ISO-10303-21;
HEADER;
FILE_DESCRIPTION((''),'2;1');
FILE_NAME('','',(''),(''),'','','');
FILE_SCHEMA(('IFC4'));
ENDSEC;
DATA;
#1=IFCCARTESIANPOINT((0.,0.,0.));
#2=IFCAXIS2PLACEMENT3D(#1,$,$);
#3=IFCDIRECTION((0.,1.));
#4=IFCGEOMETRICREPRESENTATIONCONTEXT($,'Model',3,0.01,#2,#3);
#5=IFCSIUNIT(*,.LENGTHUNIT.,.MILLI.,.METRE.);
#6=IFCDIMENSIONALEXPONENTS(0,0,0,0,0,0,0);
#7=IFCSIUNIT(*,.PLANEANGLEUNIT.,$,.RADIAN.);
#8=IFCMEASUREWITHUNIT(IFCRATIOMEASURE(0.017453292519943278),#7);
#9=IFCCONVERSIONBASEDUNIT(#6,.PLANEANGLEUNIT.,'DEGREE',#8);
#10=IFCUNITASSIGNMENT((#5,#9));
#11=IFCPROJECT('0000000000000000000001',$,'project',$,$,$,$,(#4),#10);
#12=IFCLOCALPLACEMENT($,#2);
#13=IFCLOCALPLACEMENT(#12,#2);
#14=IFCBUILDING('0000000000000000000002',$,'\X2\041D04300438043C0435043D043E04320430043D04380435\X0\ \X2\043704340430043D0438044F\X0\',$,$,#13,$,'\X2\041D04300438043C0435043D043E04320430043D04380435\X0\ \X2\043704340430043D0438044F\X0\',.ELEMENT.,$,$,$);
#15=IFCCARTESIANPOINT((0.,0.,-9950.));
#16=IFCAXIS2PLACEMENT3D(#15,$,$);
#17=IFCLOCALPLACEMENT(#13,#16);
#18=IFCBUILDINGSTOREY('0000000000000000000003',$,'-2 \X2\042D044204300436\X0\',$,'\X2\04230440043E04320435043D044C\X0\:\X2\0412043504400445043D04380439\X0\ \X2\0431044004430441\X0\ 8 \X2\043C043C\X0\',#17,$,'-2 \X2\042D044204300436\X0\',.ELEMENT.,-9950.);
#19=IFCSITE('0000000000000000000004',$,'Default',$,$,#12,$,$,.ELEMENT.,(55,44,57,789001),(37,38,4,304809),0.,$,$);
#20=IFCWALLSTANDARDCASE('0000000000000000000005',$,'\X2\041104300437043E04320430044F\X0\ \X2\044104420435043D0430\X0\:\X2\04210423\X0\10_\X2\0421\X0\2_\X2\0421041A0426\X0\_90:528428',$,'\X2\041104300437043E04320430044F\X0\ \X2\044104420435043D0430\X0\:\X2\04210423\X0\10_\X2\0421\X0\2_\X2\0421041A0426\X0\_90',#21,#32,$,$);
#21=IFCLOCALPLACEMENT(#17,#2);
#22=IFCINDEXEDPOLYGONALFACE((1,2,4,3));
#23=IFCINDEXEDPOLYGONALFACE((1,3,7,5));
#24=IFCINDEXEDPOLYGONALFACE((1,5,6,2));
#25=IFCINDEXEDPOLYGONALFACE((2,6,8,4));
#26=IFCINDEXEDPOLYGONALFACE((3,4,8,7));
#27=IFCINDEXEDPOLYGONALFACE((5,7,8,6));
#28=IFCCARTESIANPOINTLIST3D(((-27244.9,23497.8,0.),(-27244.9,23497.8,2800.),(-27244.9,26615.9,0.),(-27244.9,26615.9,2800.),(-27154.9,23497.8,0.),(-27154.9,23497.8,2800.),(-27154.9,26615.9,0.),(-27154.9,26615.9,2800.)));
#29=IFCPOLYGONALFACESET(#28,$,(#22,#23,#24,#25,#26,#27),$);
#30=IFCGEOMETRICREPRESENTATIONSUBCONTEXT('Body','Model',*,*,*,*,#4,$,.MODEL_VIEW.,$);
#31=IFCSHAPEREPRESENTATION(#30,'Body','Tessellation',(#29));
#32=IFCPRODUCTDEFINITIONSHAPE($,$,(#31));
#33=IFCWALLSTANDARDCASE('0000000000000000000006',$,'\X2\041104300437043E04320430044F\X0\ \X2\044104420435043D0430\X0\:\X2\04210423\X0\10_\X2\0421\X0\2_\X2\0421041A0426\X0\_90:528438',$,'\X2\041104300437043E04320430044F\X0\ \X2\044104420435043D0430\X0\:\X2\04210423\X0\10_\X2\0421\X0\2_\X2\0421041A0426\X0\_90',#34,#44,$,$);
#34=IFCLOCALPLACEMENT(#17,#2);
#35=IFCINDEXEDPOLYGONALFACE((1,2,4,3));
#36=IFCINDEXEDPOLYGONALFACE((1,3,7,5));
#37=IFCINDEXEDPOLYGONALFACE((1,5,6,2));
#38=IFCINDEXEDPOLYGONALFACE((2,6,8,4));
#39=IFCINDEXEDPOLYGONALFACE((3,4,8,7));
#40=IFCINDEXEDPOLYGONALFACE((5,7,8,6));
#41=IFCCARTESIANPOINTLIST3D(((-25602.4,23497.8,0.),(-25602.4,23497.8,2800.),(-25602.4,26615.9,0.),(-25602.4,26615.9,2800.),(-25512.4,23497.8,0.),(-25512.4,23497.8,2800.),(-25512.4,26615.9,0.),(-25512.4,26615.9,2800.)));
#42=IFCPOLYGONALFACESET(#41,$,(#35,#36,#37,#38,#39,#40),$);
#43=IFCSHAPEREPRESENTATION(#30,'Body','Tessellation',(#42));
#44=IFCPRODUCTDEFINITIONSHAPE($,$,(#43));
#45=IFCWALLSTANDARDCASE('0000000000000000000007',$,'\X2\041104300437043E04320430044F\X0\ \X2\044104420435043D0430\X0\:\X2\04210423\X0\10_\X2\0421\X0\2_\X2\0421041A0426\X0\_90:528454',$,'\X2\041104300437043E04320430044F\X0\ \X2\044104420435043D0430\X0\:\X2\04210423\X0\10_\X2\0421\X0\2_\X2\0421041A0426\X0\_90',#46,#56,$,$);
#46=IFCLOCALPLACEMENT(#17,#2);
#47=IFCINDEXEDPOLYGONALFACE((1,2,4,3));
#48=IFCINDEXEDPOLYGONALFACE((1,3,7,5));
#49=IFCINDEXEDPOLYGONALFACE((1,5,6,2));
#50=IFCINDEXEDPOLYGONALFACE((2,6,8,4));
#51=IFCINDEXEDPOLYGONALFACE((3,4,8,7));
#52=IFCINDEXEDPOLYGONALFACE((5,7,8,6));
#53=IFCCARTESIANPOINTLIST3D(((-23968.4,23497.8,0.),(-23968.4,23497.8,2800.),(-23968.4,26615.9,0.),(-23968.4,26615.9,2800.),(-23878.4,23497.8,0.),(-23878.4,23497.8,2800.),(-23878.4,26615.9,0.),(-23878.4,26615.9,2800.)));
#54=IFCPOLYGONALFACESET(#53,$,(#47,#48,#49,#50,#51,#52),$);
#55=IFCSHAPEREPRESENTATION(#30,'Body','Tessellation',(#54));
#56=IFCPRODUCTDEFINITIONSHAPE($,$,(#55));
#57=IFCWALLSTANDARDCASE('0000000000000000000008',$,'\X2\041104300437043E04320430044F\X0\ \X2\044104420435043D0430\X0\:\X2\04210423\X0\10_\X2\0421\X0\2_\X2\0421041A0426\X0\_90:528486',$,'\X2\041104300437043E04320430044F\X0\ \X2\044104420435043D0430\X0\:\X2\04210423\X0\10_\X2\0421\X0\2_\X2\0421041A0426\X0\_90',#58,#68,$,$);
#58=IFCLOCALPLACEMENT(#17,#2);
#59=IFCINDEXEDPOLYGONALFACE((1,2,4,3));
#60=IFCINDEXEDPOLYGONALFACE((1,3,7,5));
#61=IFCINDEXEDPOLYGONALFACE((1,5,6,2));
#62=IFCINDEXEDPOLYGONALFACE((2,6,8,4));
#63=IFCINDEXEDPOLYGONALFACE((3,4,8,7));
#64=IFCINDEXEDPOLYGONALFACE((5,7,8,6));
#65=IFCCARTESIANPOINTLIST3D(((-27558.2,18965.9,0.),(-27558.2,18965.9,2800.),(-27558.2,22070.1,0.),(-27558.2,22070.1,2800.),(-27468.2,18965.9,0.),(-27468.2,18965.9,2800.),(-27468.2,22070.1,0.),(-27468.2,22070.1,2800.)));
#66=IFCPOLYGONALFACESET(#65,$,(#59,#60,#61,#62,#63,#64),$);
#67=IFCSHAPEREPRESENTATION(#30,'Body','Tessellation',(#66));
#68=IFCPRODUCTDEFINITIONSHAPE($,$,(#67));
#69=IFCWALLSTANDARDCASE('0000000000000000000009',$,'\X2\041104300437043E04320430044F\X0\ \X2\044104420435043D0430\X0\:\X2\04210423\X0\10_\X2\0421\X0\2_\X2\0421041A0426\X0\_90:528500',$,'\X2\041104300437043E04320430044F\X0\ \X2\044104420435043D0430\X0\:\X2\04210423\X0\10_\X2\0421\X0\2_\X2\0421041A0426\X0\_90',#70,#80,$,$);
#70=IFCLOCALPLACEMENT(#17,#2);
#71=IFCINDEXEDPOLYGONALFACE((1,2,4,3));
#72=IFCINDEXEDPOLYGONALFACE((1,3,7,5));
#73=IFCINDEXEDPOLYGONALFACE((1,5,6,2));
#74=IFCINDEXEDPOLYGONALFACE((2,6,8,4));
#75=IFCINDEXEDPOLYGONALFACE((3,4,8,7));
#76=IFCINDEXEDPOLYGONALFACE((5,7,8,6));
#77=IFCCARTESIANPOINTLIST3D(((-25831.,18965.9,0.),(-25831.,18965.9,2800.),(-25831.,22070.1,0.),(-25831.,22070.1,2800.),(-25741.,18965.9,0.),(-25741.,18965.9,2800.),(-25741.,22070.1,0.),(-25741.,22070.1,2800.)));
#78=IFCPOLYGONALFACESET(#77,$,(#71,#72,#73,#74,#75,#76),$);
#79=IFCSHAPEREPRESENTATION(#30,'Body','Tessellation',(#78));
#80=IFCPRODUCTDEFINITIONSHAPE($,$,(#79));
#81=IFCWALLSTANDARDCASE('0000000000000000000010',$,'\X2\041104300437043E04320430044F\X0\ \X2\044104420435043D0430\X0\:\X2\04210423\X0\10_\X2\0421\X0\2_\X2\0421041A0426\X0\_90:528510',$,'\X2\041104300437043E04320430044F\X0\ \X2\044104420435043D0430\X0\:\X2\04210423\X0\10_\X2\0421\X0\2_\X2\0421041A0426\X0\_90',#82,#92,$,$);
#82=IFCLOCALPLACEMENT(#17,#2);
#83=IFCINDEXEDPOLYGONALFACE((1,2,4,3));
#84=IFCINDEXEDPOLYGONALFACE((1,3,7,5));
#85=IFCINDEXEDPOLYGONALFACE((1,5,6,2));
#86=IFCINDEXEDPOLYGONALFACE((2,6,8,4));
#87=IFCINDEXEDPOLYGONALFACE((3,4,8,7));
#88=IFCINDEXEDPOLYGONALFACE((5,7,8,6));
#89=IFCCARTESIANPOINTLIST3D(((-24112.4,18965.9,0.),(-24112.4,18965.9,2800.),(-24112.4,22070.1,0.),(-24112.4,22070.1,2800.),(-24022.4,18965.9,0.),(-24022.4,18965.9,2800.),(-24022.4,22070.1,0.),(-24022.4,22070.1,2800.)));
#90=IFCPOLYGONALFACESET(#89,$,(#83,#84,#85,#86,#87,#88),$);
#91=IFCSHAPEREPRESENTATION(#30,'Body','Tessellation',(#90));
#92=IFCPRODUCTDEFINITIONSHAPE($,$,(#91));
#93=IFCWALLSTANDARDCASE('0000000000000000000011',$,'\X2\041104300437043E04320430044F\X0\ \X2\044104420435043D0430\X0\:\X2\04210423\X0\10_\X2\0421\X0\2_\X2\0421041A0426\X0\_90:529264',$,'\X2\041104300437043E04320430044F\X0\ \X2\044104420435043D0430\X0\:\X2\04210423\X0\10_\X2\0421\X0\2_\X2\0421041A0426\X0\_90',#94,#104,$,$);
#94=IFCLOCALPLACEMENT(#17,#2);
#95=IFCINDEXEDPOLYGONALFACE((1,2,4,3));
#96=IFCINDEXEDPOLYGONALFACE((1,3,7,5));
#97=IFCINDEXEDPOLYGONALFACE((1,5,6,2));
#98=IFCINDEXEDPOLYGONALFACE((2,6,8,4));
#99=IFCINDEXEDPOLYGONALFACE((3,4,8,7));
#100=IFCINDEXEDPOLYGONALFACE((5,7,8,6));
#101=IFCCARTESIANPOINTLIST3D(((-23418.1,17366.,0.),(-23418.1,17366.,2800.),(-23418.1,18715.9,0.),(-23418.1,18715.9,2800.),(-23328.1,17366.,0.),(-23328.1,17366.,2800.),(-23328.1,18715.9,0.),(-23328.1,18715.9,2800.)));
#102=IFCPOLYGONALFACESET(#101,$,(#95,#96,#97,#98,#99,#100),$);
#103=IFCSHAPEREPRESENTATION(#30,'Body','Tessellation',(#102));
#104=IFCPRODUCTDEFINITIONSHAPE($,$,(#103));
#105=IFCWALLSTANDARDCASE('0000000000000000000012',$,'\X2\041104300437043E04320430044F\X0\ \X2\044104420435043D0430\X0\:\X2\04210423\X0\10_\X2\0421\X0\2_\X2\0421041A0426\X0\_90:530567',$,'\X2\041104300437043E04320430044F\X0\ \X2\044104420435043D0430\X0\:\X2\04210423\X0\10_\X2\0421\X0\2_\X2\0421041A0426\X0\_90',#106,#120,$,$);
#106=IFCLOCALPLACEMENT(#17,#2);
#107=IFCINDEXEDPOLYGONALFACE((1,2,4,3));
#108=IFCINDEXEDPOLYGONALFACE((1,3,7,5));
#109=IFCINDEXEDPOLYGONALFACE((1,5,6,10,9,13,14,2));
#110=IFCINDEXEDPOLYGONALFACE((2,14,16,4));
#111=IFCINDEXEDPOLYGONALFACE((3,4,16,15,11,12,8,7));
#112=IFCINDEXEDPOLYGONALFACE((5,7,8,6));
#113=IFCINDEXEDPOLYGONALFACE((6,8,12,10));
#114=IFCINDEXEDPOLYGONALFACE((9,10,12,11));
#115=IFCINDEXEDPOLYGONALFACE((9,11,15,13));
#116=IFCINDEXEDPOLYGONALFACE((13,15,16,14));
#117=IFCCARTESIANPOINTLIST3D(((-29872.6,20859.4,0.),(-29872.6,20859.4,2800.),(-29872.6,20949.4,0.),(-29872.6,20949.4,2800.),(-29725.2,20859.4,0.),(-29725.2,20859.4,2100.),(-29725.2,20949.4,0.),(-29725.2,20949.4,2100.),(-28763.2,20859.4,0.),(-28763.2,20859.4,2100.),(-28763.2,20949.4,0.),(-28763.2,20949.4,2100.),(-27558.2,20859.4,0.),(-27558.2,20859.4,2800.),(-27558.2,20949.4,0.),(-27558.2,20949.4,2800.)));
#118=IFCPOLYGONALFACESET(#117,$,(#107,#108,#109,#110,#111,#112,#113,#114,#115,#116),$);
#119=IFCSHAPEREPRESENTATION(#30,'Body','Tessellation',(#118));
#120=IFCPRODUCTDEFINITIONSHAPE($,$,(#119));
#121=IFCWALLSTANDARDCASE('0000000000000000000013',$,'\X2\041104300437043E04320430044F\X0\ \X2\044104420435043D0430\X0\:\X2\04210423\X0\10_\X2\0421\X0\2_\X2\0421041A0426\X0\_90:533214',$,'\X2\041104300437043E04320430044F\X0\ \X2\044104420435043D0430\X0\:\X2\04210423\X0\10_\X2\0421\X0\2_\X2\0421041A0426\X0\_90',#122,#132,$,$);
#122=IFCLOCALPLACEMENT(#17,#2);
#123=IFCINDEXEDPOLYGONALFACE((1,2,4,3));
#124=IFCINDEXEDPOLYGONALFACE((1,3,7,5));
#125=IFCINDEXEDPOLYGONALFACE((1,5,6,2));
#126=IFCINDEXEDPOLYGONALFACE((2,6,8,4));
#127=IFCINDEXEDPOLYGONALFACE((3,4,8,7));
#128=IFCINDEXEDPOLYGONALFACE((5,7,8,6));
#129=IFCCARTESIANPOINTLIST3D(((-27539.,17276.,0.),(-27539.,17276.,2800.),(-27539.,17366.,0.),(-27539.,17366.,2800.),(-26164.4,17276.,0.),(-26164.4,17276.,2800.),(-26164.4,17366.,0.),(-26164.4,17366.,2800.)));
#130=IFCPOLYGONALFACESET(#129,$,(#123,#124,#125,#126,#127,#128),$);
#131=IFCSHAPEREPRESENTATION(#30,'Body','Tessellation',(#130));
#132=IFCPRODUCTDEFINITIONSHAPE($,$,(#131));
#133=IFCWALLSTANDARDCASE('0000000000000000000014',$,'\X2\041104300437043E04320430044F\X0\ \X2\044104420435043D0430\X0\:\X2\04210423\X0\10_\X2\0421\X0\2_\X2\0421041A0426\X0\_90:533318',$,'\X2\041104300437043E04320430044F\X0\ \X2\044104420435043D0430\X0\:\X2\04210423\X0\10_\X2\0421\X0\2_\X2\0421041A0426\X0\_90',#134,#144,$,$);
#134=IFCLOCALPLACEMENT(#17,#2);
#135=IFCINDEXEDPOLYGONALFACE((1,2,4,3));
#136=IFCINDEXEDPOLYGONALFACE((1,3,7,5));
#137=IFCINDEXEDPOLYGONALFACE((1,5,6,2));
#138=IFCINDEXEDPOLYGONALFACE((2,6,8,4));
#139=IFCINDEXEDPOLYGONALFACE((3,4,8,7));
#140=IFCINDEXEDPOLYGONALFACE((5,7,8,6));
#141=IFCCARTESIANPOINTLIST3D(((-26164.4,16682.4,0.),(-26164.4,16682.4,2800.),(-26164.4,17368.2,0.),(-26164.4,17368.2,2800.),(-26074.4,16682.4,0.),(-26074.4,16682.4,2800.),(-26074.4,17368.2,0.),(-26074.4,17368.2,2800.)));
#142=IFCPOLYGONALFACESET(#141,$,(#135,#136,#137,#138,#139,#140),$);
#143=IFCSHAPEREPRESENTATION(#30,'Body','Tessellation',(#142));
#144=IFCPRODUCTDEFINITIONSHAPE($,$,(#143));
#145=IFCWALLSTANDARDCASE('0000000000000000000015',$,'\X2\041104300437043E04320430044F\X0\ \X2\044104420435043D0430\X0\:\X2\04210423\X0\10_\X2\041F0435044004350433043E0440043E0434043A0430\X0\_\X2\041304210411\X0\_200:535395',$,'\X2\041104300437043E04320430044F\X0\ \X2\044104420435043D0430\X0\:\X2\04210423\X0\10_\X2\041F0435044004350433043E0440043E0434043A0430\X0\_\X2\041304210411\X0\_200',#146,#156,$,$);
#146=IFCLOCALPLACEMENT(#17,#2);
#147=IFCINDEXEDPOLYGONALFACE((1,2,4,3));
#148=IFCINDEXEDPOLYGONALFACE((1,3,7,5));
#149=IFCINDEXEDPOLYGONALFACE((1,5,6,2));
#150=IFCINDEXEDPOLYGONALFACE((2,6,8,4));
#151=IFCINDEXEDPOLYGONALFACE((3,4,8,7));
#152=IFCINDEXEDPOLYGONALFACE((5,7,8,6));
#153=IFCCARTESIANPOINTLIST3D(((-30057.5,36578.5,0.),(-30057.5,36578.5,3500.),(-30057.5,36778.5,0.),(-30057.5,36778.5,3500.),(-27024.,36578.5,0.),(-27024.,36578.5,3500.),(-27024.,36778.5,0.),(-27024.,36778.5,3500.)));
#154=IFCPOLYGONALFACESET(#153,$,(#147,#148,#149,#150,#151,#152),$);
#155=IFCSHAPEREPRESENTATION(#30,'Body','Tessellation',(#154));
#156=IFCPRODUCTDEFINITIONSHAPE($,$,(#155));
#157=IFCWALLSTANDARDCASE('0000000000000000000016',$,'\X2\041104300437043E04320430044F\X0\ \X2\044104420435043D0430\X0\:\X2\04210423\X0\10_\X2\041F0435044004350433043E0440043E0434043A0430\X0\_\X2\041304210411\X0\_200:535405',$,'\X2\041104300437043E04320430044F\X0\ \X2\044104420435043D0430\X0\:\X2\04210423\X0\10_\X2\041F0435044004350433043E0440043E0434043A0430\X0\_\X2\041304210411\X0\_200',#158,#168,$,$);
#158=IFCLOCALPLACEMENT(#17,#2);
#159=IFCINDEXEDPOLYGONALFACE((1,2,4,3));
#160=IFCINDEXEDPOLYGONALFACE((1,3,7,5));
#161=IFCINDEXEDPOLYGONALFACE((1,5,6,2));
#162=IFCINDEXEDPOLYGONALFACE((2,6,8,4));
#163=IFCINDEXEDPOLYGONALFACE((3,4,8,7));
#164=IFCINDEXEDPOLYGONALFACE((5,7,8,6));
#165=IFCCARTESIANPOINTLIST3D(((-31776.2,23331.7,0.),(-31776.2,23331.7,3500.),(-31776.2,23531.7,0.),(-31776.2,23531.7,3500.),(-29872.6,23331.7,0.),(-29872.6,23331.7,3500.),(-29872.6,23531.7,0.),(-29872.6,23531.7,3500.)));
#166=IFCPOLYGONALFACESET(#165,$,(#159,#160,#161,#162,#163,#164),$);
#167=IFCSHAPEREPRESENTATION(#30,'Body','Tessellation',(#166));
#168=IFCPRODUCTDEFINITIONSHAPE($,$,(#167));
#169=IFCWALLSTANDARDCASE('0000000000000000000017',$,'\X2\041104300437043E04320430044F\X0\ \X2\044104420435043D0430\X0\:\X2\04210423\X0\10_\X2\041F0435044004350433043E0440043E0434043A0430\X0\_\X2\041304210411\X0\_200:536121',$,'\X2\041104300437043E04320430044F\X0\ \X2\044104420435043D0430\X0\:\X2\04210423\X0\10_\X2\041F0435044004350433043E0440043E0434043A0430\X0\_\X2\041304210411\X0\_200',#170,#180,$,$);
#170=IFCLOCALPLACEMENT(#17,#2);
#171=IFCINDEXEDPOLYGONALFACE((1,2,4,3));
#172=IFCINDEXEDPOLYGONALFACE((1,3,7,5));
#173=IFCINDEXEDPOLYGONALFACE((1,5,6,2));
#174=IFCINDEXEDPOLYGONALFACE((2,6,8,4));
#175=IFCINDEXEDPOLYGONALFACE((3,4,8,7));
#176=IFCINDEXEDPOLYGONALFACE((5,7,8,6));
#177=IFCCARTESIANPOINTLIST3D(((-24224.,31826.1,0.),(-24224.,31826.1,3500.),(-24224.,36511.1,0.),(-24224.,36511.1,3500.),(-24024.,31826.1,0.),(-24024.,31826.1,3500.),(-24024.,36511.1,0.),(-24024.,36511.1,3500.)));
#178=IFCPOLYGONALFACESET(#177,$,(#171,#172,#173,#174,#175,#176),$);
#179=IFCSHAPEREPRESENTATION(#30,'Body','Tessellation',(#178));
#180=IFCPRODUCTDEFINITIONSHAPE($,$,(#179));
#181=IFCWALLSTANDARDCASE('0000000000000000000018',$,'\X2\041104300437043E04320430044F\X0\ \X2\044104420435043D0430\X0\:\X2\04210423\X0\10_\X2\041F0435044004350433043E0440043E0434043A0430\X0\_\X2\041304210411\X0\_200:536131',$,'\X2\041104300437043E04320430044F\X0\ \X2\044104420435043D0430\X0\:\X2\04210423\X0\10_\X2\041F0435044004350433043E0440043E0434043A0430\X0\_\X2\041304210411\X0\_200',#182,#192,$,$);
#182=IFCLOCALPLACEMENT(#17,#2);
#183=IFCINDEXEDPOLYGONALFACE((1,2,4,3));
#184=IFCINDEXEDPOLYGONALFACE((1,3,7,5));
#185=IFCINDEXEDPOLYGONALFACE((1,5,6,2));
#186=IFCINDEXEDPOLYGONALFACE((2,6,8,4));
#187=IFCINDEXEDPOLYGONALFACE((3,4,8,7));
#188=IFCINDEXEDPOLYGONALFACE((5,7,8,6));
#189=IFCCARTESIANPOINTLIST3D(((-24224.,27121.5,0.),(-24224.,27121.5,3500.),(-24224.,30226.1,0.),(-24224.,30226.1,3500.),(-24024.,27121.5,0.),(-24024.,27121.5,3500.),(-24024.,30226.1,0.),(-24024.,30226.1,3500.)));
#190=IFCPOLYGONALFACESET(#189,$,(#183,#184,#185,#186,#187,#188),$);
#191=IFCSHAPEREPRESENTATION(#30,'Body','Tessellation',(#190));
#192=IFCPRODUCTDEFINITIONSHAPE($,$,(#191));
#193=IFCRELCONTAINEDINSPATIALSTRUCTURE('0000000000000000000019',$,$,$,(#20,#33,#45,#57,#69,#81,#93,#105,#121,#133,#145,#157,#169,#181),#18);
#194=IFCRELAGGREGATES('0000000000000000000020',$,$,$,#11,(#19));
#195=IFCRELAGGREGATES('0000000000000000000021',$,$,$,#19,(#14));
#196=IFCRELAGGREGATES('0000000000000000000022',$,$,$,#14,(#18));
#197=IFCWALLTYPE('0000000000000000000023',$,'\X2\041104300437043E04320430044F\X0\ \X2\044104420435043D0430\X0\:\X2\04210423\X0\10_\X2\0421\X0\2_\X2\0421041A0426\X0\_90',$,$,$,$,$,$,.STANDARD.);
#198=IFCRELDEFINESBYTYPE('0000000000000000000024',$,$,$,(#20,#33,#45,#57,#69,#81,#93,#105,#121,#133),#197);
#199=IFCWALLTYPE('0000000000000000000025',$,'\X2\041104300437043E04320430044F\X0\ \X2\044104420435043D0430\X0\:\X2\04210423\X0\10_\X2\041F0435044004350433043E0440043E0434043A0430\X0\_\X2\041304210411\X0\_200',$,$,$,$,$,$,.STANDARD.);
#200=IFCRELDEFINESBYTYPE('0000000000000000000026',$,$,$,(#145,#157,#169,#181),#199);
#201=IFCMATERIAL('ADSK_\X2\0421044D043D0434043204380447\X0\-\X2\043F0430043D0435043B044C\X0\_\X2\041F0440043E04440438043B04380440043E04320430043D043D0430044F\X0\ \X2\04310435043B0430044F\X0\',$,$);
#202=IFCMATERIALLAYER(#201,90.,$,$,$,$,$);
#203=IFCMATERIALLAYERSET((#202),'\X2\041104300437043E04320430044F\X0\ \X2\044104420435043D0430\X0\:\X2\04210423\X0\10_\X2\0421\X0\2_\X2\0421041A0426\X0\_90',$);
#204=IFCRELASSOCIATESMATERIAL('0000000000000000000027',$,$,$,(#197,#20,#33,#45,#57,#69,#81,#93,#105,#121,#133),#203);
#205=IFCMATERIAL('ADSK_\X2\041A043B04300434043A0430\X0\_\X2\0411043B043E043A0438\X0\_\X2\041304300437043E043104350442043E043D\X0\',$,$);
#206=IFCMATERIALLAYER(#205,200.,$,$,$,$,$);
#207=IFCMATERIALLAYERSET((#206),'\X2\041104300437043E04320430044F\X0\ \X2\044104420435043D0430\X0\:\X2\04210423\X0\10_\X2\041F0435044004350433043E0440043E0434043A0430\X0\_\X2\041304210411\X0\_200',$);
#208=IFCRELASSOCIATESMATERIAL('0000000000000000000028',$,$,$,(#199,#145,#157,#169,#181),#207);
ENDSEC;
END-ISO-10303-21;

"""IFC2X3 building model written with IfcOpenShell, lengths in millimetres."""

from ifc_helpers import new_model, entity, si_unit, converted_unit, direction, frame, frame_2d, origin, place, context, subcontext, project, spatial, rectangle, extrude, material, layer, layer_set, layer_usage, type_object, element, save


model = new_model("IFC2X3")

# Units and contexts
model_context = context("Model", 3, precision=0.01, world=origin(), true_north=direction((0.0, 1.0)))
body_context = subcontext(model_context, "Body", "Model", "MODEL_VIEW")
ifc_project = project(units=[si_unit("LENGTHUNIT", "METRE", prefix="MILLI"), converted_unit("PLANEANGLEUNIT", "DEGREE", entity("IfcRatioMeasure", 0.017453292519943278), si_unit("PLANEANGLEUNIT", "RADIAN"), dimensions=[0, 0, 0, 0, 0, 0, 0])], contexts=[model_context])

# Site, building, storey
site_placement = place(None, origin())
site = spatial("IfcSite", under=ifc_project, at=site_placement, Name="Default", CompositionType="ELEMENT", RefLatitude=(55, 44, 57, 789001), RefLongitude=(37, 38, 4, 304809), RefElevation=0.0)
building_placement = place(site_placement, origin())
building = spatial("IfcBuilding", under=site, at=building_placement, Name="Наименование здания", LongName="Наименование здания", CompositionType="ELEMENT")
storey_placement = place(building_placement, frame((0.0, 0.0, -9950.0)))
storey = spatial("IfcBuildingStorey", under=building, at=storey_placement, Name="-2 Этаж", ObjectType="Уровень:Верхний брус 8 мм", LongName="-2 Этаж", CompositionType="ELEMENT", Elevation=-9950.0)

# Walls
ifc_material_1 = material(Name="ADSK_Сэндвич-панель_Профилированная белая")
ifc_layer_1 = layer(ifc_material_1, 90.0)
ifc_layer_set_1 = layer_set([ifc_layer_1], Name="Базовая стена:СУ10_С2_СКЦ_90")
ifc_layer_usage_1 = layer_usage(ifc_layer_set_1, "AXIS2", "NEGATIVE", 45.0)
wall_type_1 = type_object("IfcWallType", Name="Базовая стена:СУ10_С2_СКЦ_90", PredefinedType="STANDARD", material=ifc_layer_set_1)
wall_1_placement = place(storey_placement, frame((-27199.9, 26615.9, 0.0), z_axis=(0.0, 0.0, 1.0), x_axis=(0.0, -1.0, 0.0)))
element("IfcWallStandardCase", 1, at=wall_1_placement, inside=storey, type_object=wall_type_1, material=ifc_layer_usage_1, Name="Базовая стена:СУ10_С2_СКЦ_90:528428", ObjectType="Базовая стена:СУ10_С2_СКЦ_90", context=body_context, shape_type="SweptSolid", body=[
    extrude(rectangle(XDim=3118.1, YDim=90.0, at=frame_2d((1559.1, 0.0), x_axis=(-1.0, 0.0))), origin(), (0.0, 0.0, 1.0), 2800.0),
])
wall_2_placement = place(storey_placement, frame((-25557.4, 26615.9, 0.0), z_axis=(0.0, 0.0, 1.0), x_axis=(0.0, -1.0, 0.0)))
element("IfcWallStandardCase", 2, at=wall_2_placement, inside=storey, type_object=wall_type_1, material=ifc_layer_usage_1, Name="Базовая стена:СУ10_С2_СКЦ_90:528438", ObjectType="Базовая стена:СУ10_С2_СКЦ_90", context=body_context, shape_type="SweptSolid", body=[
    extrude(rectangle(XDim=3118.1, YDim=90.0, at=frame_2d((1559.1, 0.0), x_axis=(-1.0, 0.0))), origin(), (0.0, 0.0, 1.0), 2800.0),
])
wall_3_placement = place(storey_placement, frame((-23923.4, 26615.9, 0.0), z_axis=(0.0, 0.0, 1.0), x_axis=(0.0, -1.0, 0.0)))
element("IfcWallStandardCase", 3, at=wall_3_placement, inside=storey, type_object=wall_type_1, material=ifc_layer_usage_1, Name="Базовая стена:СУ10_С2_СКЦ_90:528454", ObjectType="Базовая стена:СУ10_С2_СКЦ_90", context=body_context, shape_type="SweptSolid", body=[
    extrude(rectangle(XDim=3118.1, YDim=90.0, at=frame_2d((1559.1, 0.0), x_axis=(-1.0, 0.0))), origin(), (0.0, 0.0, 1.0), 2800.0),
])
wall_4_placement = place(storey_placement, frame((-27513.2, 22070.1, 0.0), z_axis=(0.0, 0.0, 1.0), x_axis=(0.0, -1.0, 0.0)))
element("IfcWallStandardCase", 4, at=wall_4_placement, inside=storey, type_object=wall_type_1, material=ifc_layer_usage_1, Name="Базовая стена:СУ10_С2_СКЦ_90:528486", ObjectType="Базовая стена:СУ10_С2_СКЦ_90", context=body_context, shape_type="SweptSolid", body=[
    extrude(rectangle(XDim=3104.2, YDim=90.0, at=frame_2d((1552.1, 0.0), x_axis=(-1.0, 0.0))), origin(), (0.0, 0.0, 1.0), 2800.0),
])
wall_5_placement = place(storey_placement, frame((-25786.0, 22070.1, 0.0), z_axis=(0.0, 0.0, 1.0), x_axis=(0.0, -1.0, 0.0)))
element("IfcWallStandardCase", 5, at=wall_5_placement, inside=storey, type_object=wall_type_1, material=ifc_layer_usage_1, Name="Базовая стена:СУ10_С2_СКЦ_90:528500", ObjectType="Базовая стена:СУ10_С2_СКЦ_90", context=body_context, shape_type="SweptSolid", body=[
    extrude(rectangle(XDim=3104.2, YDim=90.0, at=frame_2d((1552.1, 0.0), x_axis=(-1.0, 0.0))), origin(), (0.0, 0.0, 1.0), 2800.0),
])
wall_6_placement = place(storey_placement, frame((-24067.4, 22070.1, 0.0), z_axis=(0.0, 0.0, 1.0), x_axis=(0.0, -1.0, 0.0)))
element("IfcWallStandardCase", 6, at=wall_6_placement, inside=storey, type_object=wall_type_1, material=ifc_layer_usage_1, Name="Базовая стена:СУ10_С2_СКЦ_90:528510", ObjectType="Базовая стена:СУ10_С2_СКЦ_90", context=body_context, shape_type="SweptSolid", body=[
    extrude(rectangle(XDim=3104.2, YDim=90.0, at=frame_2d((1552.1, 0.0), x_axis=(-1.0, 0.0))), origin(), (0.0, 0.0, 1.0), 2800.0),
])
wall_7_placement = place(storey_placement, frame((-23373.1, 18715.9, 0.0), z_axis=(0.0, 0.0, 1.0), x_axis=(0.0, -1.0, 0.0)))
element("IfcWallStandardCase", 7, at=wall_7_placement, inside=storey, type_object=wall_type_1, material=ifc_layer_usage_1, Name="Базовая стена:СУ10_С2_СКЦ_90:529264", ObjectType="Базовая стена:СУ10_С2_СКЦ_90", context=body_context, shape_type="SweptSolid", body=[
    extrude(rectangle(XDim=1350.0, YDim=90.0, at=frame_2d((675.0, 0.0), x_axis=(-1.0, 0.0))), origin(), (0.0, 0.0, 1.0), 2800.0),
])

# Wall, opening
wall_8_placement = place(storey_placement, frame((-27558.2, 20904.4, 0.0), z_axis=(0.0, 0.0, 1.0), x_axis=(-1.0, 0.0, 0.0)))
wall_8 = element("IfcWallStandardCase", 8, at=wall_8_placement, inside=storey, type_object=wall_type_1, material=ifc_layer_usage_1, Name="Базовая стена:СУ10_С2_СКЦ_90:530567", ObjectType="Базовая стена:СУ10_С2_СКЦ_90", context=body_context, shape_type="SweptSolid", body=[
    extrude(rectangle(XDim=2314.5, YDim=90.0, at=frame_2d((1157.2, 0.0), x_axis=(1.0, 0.0))), origin(), (0.0, 0.0, 1.0), 2800.0),
])
opening_1_placement = place(wall_8_placement, origin())
element("IfcOpeningElement", 9, at=opening_1_placement, cuts=wall_8, ObjectType="Opening", context=body_context, shape_type="SweptSolid", body=[
    extrude(rectangle(XDim=2100.0, YDim=962.0, at=frame_2d((0.0, 0.0), x_axis=(1.0, 0.0))), frame((1686.0, -45.0, 1050.0), z_axis=(0.0, 1.0, 0.0), x_axis=(0.0, 0.0, -1.0)), (0.0, 0.0, 1.0), 90.0),
])

# Walls
wall_9_placement = place(storey_placement, frame((-26164.4, 17321.0, 0.0), z_axis=(0.0, 0.0, 1.0), x_axis=(-1.0, 0.0, 0.0)))
element("IfcWallStandardCase", 10, at=wall_9_placement, inside=storey, type_object=wall_type_1, material=ifc_layer_usage_1, Name="Базовая стена:СУ10_С2_СКЦ_90:533214", ObjectType="Базовая стена:СУ10_С2_СКЦ_90", context=body_context, shape_type="SweptSolid", body=[
    extrude(rectangle(XDim=1374.6, YDim=90.0, at=frame_2d((687.3, 0.0), x_axis=(-1.0, 0.0))), origin(), (0.0, 0.0, 1.0), 2800.0),
])
wall_10_placement = place(storey_placement, frame((-26119.4, 17368.2, 0.0), z_axis=(0.0, 0.0, 1.0), x_axis=(0.0, -1.0, 0.0)))
element("IfcWallStandardCase", 11, at=wall_10_placement, inside=storey, type_object=wall_type_1, material=ifc_layer_usage_1, Name="Базовая стена:СУ10_С2_СКЦ_90:533318", ObjectType="Базовая стена:СУ10_С2_СКЦ_90", context=body_context, shape_type="SweptSolid", body=[
    extrude(rectangle(XDim=685.8, YDim=90.0, at=frame_2d((342.9, 0.0), x_axis=(-1.0, 0.0))), origin(), (0.0, 0.0, 1.0), 2800.0),
])
ifc_material_2 = material(Name="ADSK_Кладка_Блоки_Газобетон")
ifc_layer_2 = layer(ifc_material_2, 200.0)
ifc_layer_set_2 = layer_set([ifc_layer_2], Name="Базовая стена:СУ10_Перегородка_ГСБ_200")
ifc_layer_usage_2 = layer_usage(ifc_layer_set_2, "AXIS2", "NEGATIVE", 100.0)
wall_type_2 = type_object("IfcWallType", Name="Базовая стена:СУ10_Перегородка_ГСБ_200", PredefinedType="STANDARD", material=ifc_layer_set_2)
wall_11_placement = place(storey_placement, frame((-27024.0, 36678.5, 0.0), z_axis=(0.0, 0.0, 1.0), x_axis=(-1.0, 0.0, 0.0)))
element("IfcWallStandardCase", 12, at=wall_11_placement, inside=storey, type_object=wall_type_2, material=ifc_layer_usage_2, Name="Базовая стена:СУ10_Перегородка_ГСБ_200:535395", ObjectType="Базовая стена:СУ10_Перегородка_ГСБ_200", context=body_context, shape_type="SweptSolid", body=[
    extrude(rectangle(XDim=3033.5, YDim=200.0, at=frame_2d((1516.7, 0.0), x_axis=(-1.0, 0.0))), origin(), (0.0, 0.0, 1.0), 3500.0),
])
wall_12_placement = place(storey_placement, frame((-29872.6, 23431.7, 0.0), z_axis=(0.0, 0.0, 1.0), x_axis=(-1.0, 0.0, 0.0)))
element("IfcWallStandardCase", 13, at=wall_12_placement, inside=storey, type_object=wall_type_2, material=ifc_layer_usage_2, Name="Базовая стена:СУ10_Перегородка_ГСБ_200:535405", ObjectType="Базовая стена:СУ10_Перегородка_ГСБ_200", context=body_context, shape_type="SweptSolid", body=[
    extrude(rectangle(XDim=1903.5, YDim=200.0, at=frame_2d((951.8, 0.0), x_axis=(-1.0, 0.0))), origin(), (0.0, 0.0, 1.0), 3500.0),
])
wall_13_placement = place(storey_placement, frame((-24124.0, 31826.1, 0.0), z_axis=(0.0, 0.0, 1.0), x_axis=(0.0, 1.0, 0.0)))
element("IfcWallStandardCase", 14, at=wall_13_placement, inside=storey, type_object=wall_type_2, material=ifc_layer_usage_2, Name="Базовая стена:СУ10_Перегородка_ГСБ_200:536121", ObjectType="Базовая стена:СУ10_Перегородка_ГСБ_200", context=body_context, shape_type="SweptSolid", body=[
    extrude(rectangle(XDim=4685.0, YDim=200.0, at=frame_2d((2342.5, 0.0), x_axis=(-1.0, 0.0))), origin(), (0.0, 0.0, 1.0), 3500.0),
])
wall_14_placement = place(storey_placement, frame((-24124.0, 27121.5, 0.0), z_axis=(0.0, 0.0, 1.0), x_axis=(0.0, 1.0, 0.0)))
element("IfcWallStandardCase", 15, at=wall_14_placement, inside=storey, type_object=wall_type_2, material=ifc_layer_usage_2, Name="Базовая стена:СУ10_Перегородка_ГСБ_200:536131", ObjectType="Базовая стена:СУ10_Перегородка_ГСБ_200", context=body_context, shape_type="SweptSolid", body=[
    extrude(rectangle(XDim=3104.6, YDim=200.0, at=frame_2d((1552.3, 0.0), x_axis=(-1.0, 0.0))), origin(), (0.0, 0.0, 1.0), 3500.0),
])

save(model, "model.ifc")
